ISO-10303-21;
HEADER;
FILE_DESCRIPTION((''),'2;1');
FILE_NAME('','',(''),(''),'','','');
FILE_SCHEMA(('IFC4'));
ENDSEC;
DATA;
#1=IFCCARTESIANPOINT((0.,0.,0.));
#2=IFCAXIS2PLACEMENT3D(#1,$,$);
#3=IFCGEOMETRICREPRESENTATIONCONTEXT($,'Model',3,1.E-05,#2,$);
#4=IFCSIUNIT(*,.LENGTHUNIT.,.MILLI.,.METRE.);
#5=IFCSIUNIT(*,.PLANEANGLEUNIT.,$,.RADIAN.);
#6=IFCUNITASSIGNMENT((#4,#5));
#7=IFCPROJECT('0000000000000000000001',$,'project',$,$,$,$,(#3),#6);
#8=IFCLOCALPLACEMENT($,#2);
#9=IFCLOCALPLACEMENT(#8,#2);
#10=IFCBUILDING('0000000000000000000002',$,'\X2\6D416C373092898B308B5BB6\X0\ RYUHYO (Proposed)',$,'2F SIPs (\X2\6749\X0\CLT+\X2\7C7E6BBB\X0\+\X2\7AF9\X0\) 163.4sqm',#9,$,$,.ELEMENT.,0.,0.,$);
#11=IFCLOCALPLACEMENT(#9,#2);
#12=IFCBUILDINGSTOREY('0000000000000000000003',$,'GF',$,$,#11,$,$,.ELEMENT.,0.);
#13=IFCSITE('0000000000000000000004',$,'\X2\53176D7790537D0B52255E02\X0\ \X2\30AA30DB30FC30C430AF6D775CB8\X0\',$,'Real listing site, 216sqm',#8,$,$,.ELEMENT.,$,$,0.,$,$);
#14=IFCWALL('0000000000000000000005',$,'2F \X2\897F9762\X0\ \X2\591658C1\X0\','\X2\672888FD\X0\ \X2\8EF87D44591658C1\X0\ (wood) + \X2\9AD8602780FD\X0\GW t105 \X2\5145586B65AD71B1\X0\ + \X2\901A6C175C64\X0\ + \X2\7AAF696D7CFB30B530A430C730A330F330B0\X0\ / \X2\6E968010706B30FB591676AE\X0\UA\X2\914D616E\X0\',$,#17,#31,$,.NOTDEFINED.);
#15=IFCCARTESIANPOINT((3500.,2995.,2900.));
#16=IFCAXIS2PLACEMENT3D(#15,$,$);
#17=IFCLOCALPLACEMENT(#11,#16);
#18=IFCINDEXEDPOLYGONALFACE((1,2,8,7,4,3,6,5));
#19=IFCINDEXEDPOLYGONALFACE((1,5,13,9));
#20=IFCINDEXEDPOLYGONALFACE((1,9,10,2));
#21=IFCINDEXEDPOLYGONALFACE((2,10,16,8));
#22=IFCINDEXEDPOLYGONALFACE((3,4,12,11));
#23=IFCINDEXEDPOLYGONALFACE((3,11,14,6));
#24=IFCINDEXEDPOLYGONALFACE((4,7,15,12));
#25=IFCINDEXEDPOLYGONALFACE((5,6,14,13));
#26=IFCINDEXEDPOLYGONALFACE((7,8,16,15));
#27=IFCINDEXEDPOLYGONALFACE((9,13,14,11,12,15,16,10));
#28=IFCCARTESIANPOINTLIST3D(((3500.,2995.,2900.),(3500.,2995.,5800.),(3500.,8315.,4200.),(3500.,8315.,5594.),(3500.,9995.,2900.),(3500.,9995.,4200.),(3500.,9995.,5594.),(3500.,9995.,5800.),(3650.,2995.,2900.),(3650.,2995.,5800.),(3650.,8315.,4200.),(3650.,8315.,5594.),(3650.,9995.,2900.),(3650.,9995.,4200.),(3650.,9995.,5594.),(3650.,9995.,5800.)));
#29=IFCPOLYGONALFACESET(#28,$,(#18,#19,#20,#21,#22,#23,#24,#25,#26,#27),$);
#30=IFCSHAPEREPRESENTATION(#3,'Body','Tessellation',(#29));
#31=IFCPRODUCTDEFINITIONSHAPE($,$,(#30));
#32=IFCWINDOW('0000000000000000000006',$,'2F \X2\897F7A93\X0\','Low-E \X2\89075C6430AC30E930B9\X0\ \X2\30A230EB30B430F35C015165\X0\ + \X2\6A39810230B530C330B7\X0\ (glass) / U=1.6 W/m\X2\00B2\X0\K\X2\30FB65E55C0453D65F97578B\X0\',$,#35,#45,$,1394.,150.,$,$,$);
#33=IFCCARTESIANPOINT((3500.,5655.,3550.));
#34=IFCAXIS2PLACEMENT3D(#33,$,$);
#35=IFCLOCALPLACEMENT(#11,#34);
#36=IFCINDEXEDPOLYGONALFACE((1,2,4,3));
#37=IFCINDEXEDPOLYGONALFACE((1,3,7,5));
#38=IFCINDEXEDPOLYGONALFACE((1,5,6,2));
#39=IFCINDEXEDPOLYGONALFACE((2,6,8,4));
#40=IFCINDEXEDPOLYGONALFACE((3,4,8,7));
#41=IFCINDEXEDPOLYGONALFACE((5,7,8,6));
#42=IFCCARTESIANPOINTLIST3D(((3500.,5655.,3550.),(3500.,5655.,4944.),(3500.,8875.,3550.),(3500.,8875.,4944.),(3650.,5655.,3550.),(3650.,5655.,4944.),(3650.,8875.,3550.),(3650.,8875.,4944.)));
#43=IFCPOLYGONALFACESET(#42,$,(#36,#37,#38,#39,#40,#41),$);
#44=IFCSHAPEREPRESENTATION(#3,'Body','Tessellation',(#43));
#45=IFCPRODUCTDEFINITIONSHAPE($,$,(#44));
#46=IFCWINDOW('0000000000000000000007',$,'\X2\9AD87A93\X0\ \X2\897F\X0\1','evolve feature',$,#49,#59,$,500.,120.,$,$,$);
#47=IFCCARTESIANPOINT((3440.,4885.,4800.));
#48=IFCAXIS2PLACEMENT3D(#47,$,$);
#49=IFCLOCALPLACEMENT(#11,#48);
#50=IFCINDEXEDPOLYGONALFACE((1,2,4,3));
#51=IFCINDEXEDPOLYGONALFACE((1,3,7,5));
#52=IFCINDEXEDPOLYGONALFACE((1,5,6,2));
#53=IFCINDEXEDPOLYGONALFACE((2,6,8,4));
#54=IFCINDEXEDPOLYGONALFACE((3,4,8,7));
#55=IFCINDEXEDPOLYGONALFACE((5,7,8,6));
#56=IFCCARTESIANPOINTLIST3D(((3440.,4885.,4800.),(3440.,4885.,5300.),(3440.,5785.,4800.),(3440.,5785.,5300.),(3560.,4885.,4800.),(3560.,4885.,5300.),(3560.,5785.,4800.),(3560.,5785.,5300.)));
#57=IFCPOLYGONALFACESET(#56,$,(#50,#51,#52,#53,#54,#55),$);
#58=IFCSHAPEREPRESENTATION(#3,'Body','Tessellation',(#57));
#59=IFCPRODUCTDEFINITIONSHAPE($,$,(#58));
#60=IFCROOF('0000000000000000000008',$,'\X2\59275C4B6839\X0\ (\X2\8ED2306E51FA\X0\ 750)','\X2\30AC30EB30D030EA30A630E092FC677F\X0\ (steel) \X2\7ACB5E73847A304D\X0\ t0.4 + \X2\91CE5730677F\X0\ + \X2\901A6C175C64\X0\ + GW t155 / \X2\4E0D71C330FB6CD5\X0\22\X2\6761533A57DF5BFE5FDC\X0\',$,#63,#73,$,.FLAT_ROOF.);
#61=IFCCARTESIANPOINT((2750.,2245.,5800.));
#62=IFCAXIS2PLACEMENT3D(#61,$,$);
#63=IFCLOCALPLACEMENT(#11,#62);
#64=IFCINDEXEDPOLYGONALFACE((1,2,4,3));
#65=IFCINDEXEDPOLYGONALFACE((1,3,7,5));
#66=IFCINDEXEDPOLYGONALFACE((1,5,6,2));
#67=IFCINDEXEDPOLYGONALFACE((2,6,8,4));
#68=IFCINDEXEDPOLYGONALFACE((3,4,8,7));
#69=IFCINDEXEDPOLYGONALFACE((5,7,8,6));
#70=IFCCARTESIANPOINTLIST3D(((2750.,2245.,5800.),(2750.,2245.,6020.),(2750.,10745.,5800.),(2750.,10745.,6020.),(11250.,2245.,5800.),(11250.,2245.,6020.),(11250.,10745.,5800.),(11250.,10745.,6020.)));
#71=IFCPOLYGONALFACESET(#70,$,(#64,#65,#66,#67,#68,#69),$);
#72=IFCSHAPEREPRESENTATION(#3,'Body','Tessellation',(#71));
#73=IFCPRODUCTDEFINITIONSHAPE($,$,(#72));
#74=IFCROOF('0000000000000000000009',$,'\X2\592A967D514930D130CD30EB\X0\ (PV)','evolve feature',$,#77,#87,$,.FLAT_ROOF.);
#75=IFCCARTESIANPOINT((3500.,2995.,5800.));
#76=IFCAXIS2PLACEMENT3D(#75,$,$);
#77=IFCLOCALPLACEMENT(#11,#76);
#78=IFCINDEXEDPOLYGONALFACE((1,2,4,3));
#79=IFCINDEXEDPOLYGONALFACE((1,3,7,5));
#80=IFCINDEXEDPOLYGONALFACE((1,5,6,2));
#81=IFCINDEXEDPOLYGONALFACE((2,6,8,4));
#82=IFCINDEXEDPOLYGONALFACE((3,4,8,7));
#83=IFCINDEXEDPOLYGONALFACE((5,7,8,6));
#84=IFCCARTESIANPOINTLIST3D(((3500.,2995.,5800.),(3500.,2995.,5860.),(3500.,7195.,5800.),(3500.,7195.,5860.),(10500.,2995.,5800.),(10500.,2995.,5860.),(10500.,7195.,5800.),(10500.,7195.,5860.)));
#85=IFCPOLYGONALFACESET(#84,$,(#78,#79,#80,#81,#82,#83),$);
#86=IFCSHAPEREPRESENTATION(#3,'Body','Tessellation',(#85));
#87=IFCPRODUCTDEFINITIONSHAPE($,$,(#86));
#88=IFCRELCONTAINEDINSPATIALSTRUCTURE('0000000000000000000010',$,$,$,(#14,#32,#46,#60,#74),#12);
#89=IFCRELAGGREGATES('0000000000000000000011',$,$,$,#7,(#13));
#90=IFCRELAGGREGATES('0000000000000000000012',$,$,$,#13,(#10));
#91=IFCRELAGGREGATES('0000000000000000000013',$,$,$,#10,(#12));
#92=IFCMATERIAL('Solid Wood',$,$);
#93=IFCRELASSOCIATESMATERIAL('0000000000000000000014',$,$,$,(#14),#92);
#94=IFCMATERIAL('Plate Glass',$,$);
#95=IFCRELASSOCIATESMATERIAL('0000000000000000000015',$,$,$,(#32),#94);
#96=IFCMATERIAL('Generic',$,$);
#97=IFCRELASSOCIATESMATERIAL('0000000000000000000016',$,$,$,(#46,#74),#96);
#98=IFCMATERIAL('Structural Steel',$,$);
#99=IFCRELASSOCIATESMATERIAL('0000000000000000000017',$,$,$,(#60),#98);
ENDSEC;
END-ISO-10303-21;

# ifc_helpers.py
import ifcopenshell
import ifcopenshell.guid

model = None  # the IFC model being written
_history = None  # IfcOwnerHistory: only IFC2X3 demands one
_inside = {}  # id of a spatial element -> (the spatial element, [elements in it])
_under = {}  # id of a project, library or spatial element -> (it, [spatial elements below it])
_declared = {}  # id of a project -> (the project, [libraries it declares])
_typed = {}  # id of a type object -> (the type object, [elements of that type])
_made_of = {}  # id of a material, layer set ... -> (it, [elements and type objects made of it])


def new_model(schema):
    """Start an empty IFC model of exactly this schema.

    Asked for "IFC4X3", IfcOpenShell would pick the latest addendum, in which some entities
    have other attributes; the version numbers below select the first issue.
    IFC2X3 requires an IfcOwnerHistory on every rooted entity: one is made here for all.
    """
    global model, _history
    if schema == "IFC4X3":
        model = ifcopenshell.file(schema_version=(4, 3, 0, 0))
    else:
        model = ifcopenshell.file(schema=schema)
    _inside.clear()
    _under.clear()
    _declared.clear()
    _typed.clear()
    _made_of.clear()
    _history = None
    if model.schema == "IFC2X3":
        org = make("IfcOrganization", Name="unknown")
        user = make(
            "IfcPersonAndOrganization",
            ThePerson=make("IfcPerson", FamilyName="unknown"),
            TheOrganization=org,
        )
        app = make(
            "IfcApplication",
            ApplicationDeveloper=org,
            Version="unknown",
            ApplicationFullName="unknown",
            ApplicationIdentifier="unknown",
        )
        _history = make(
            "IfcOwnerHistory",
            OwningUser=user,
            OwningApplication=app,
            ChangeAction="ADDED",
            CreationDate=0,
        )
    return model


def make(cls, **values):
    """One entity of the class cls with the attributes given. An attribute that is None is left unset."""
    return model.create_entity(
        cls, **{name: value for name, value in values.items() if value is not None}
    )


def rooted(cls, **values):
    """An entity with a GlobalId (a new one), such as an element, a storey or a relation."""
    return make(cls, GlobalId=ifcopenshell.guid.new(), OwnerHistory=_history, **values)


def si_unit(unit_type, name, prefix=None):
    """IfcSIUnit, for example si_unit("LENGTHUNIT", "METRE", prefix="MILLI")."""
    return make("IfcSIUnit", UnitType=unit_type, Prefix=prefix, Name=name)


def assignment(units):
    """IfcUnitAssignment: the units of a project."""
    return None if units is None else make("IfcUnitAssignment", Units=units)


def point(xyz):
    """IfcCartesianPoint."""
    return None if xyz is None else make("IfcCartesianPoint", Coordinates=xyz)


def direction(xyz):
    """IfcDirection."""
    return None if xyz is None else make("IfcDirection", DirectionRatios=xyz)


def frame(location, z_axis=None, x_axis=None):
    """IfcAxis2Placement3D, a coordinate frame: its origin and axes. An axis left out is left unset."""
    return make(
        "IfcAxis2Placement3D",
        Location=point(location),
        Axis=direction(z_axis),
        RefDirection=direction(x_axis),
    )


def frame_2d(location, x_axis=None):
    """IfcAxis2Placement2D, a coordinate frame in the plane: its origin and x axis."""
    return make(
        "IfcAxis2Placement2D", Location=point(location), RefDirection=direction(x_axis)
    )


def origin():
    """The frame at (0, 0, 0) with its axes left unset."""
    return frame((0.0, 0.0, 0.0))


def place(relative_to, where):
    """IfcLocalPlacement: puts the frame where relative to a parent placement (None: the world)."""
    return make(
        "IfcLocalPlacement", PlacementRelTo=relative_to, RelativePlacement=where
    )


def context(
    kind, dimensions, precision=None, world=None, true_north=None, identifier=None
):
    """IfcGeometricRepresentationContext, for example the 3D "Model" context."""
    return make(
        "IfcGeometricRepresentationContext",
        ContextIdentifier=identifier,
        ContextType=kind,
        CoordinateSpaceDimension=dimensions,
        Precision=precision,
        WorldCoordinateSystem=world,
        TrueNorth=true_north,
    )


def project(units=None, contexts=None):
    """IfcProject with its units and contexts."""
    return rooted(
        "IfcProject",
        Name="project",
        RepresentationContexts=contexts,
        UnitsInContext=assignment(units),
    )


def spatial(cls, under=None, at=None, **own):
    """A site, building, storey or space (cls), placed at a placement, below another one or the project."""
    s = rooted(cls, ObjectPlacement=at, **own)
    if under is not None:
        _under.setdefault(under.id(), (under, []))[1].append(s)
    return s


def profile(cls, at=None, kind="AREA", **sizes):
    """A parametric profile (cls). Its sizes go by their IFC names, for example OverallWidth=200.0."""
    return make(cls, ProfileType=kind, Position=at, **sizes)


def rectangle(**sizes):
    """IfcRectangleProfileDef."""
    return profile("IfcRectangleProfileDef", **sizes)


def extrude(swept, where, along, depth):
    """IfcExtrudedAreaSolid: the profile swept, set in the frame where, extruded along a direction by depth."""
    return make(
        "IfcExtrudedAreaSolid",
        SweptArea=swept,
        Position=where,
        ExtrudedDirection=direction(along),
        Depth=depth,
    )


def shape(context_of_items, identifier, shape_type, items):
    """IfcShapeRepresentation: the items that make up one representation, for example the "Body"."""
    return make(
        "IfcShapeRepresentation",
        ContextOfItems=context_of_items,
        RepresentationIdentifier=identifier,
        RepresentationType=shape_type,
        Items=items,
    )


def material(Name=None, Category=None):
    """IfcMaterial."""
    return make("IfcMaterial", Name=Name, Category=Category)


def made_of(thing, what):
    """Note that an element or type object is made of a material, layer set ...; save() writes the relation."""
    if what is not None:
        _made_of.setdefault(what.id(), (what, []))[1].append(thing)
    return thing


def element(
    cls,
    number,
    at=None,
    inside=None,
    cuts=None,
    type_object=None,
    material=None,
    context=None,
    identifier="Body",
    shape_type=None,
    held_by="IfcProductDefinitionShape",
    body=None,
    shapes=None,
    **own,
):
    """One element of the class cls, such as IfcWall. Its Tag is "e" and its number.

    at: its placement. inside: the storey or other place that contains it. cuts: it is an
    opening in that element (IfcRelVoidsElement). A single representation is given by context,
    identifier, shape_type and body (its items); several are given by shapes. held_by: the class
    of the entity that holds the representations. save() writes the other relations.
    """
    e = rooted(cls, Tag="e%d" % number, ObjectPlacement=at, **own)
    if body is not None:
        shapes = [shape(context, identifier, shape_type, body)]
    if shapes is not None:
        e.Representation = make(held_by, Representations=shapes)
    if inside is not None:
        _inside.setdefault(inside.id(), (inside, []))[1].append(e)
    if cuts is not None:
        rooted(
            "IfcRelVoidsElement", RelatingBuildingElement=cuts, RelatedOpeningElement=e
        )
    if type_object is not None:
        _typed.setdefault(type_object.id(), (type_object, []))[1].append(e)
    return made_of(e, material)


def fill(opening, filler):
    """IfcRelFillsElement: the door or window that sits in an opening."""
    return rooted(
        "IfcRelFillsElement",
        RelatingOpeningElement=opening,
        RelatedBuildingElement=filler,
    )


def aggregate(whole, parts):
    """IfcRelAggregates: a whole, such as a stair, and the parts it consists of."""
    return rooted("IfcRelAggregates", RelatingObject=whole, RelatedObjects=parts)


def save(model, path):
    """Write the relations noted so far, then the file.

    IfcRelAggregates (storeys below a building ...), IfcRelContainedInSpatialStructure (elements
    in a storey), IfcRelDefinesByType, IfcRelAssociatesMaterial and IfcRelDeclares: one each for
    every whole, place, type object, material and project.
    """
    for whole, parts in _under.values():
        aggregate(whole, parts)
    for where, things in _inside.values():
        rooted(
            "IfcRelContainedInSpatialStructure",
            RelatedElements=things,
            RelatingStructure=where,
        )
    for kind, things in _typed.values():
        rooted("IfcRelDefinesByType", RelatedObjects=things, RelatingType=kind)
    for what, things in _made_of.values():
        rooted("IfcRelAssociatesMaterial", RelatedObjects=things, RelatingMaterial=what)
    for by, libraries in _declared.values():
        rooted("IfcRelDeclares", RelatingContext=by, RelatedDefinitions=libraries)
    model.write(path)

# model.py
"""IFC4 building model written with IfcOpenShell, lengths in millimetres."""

from ifc_helpers import new_model, si_unit, frame, frame_2d, origin, place, context, project, spatial, rectangle, extrude, material, element, fill, save


model = new_model("IFC4")

# Units and contexts
model_context = context("Model", 3, precision=1e-05, world=origin())
ifc_project = project(units=[si_unit("LENGTHUNIT", "METRE", prefix="MILLI"), si_unit("PLANEANGLEUNIT", "RADIAN")], contexts=[model_context])

# Site, building, storey
site_placement = place(None, origin())
site = spatial("IfcSite", under=ifc_project, at=site_placement, Name="北海道紋別市 オホーツク海岸", ObjectType="Real listing site, 216sqm", CompositionType="ELEMENT", RefElevation=0.0)
building_placement = place(site_placement, origin())
building = spatial("IfcBuilding", under=site, at=building_placement, Name="流氷を見る家 RYUHYO (Proposed)", ObjectType="2F SIPs (杉CLT+籾殻+竹) 163.4sqm", CompositionType="ELEMENT", ElevationOfRefHeight=0.0, ElevationOfTerrain=0.0)
storey_placement = place(building_placement, origin())
storey = spatial("IfcBuildingStorey", under=building, at=storey_placement, Name="GF", CompositionType="ELEMENT", Elevation=0.0)

# Shared definitions
ifc_material_1 = material(Name="Solid Wood")
ifc_material_2 = material(Name="Generic")

# Shared definitions
ifc_material_3 = material(Name="Plate Glass")

# Wall, openings, windows
wall_1_placement = place(storey_placement, frame((3500.0, 2995.0, 2900.0)))
wall_1 = element("IfcWall", 1, at=wall_1_placement, inside=storey, material=ifc_material_1, Name="2F 西面 外壁", Description="木製 軸組外壁 (wood) + 高性能GW t105 充填断熱 + 通気層 + 窯業系サイディング / 準耐火・外皮UA配慮", PredefinedType="NOTDEFINED", context=model_context, shape_type="SweptSolid", body=[
    extrude(rectangle(XDim=150.0, YDim=7000.0, at=frame_2d((75.0, 3500.0))), frame((3500.0, 2995.0, 2900.0)), (0.0, 0.0, 1.0), 2900.0),
])
opening_1_placement = place(storey_placement, frame((3500.0, 5655.0, 3550.0)))
opening_1 = element("IfcOpeningElement", 2, at=opening_1_placement, cuts=wall_1, PredefinedType="NOTDEFINED", context=model_context, shape_type="SweptSolid", body=[
    extrude(rectangle(XDim=150.0, YDim=3220.0, at=frame_2d((75.0, 1610.0))), frame((3500.0, 5655.0, 3550.0)), (0.0, 0.0, 1.0), 1394.0),
])
opening_2_placement = place(storey_placement, frame((3440.0, 4885.0, 4800.0)))
opening_2 = element("IfcOpeningElement", 3, at=opening_2_placement, cuts=wall_1, PredefinedType="NOTDEFINED", context=model_context, shape_type="SweptSolid", body=[
    extrude(rectangle(XDim=120.0, YDim=900.0, at=frame_2d((60.0, 450.0))), frame((3440.0, 4885.0, 4800.0)), (0.0, 0.0, 1.0), 500.0),
])
window_1_placement = place(storey_placement, frame((3500.0, 5655.0, 3550.0)))
window_1 = element("IfcWindow", 4, at=window_1_placement, inside=storey, material=ifc_material_3, Name="2F 西窓", Description="Low-E 複層ガラス アルゴン封入 + 樹脂サッシ (glass) / U=1.6 W/m²K・日射取得型", OverallHeight=1394.0, OverallWidth=150.0, context=model_context, shape_type="SweptSolid", body=[
    extrude(rectangle(XDim=150.0, YDim=3220.0, at=frame_2d((75.0, 1610.0))), frame((3500.0, 5655.0, 3550.0)), (0.0, 0.0, 1.0), 1394.0),
])
fill(opening_1, window_1)
window_2_placement = place(storey_placement, frame((3440.0, 4885.0, 4800.0)))
window_2 = element("IfcWindow", 5, at=window_2_placement, inside=storey, material=ifc_material_2, Name="高窓 西1", Description="evolve feature", OverallHeight=500.0, OverallWidth=120.0, context=model_context, shape_type="SweptSolid", body=[
    extrude(rectangle(XDim=120.0, YDim=900.0, at=frame_2d((60.0, 450.0))), frame((3440.0, 4885.0, 4800.0)), (0.0, 0.0, 1.0), 500.0),
])
fill(opening_2, window_2)

# Roofs
ifc_material_4 = material(Name="Structural Steel")
roof_1_placement = place(storey_placement, frame((2750.0, 2245.0, 5800.0)))
element("IfcRoof", 6, at=roof_1_placement, inside=storey, material=ifc_material_4, Name="大屋根 (軒の出 750)", Description="ガルバリウム鋼板 (steel) 立平葺き t0.4 + 野地板 + 通気層 + GW t155 / 不燃・法22条区域対応", PredefinedType="FLAT_ROOF", context=model_context, shape_type="SweptSolid", body=[
    extrude(rectangle(XDim=8500.0, YDim=8500.0, at=frame_2d((4250.0, 4250.0))), frame((2750.0, 2245.0, 5800.0)), (0.0, 0.0, 1.0), 220.0),
])
roof_2_placement = place(storey_placement, frame((3500.0, 2995.0, 5800.0)))
element("IfcRoof", 7, at=roof_2_placement, inside=storey, material=ifc_material_2, Name="太陽光パネル (PV)", Description="evolve feature", PredefinedType="FLAT_ROOF", context=model_context, shape_type="SweptSolid", body=[
    extrude(rectangle(XDim=7000.0, YDim=4200.0, at=frame_2d((3500.0, 2100.0))), frame((3500.0, 2995.0, 5800.0)), (0.0, 0.0, 1.0), 60.0),
])

save(model, "model.ifc")
